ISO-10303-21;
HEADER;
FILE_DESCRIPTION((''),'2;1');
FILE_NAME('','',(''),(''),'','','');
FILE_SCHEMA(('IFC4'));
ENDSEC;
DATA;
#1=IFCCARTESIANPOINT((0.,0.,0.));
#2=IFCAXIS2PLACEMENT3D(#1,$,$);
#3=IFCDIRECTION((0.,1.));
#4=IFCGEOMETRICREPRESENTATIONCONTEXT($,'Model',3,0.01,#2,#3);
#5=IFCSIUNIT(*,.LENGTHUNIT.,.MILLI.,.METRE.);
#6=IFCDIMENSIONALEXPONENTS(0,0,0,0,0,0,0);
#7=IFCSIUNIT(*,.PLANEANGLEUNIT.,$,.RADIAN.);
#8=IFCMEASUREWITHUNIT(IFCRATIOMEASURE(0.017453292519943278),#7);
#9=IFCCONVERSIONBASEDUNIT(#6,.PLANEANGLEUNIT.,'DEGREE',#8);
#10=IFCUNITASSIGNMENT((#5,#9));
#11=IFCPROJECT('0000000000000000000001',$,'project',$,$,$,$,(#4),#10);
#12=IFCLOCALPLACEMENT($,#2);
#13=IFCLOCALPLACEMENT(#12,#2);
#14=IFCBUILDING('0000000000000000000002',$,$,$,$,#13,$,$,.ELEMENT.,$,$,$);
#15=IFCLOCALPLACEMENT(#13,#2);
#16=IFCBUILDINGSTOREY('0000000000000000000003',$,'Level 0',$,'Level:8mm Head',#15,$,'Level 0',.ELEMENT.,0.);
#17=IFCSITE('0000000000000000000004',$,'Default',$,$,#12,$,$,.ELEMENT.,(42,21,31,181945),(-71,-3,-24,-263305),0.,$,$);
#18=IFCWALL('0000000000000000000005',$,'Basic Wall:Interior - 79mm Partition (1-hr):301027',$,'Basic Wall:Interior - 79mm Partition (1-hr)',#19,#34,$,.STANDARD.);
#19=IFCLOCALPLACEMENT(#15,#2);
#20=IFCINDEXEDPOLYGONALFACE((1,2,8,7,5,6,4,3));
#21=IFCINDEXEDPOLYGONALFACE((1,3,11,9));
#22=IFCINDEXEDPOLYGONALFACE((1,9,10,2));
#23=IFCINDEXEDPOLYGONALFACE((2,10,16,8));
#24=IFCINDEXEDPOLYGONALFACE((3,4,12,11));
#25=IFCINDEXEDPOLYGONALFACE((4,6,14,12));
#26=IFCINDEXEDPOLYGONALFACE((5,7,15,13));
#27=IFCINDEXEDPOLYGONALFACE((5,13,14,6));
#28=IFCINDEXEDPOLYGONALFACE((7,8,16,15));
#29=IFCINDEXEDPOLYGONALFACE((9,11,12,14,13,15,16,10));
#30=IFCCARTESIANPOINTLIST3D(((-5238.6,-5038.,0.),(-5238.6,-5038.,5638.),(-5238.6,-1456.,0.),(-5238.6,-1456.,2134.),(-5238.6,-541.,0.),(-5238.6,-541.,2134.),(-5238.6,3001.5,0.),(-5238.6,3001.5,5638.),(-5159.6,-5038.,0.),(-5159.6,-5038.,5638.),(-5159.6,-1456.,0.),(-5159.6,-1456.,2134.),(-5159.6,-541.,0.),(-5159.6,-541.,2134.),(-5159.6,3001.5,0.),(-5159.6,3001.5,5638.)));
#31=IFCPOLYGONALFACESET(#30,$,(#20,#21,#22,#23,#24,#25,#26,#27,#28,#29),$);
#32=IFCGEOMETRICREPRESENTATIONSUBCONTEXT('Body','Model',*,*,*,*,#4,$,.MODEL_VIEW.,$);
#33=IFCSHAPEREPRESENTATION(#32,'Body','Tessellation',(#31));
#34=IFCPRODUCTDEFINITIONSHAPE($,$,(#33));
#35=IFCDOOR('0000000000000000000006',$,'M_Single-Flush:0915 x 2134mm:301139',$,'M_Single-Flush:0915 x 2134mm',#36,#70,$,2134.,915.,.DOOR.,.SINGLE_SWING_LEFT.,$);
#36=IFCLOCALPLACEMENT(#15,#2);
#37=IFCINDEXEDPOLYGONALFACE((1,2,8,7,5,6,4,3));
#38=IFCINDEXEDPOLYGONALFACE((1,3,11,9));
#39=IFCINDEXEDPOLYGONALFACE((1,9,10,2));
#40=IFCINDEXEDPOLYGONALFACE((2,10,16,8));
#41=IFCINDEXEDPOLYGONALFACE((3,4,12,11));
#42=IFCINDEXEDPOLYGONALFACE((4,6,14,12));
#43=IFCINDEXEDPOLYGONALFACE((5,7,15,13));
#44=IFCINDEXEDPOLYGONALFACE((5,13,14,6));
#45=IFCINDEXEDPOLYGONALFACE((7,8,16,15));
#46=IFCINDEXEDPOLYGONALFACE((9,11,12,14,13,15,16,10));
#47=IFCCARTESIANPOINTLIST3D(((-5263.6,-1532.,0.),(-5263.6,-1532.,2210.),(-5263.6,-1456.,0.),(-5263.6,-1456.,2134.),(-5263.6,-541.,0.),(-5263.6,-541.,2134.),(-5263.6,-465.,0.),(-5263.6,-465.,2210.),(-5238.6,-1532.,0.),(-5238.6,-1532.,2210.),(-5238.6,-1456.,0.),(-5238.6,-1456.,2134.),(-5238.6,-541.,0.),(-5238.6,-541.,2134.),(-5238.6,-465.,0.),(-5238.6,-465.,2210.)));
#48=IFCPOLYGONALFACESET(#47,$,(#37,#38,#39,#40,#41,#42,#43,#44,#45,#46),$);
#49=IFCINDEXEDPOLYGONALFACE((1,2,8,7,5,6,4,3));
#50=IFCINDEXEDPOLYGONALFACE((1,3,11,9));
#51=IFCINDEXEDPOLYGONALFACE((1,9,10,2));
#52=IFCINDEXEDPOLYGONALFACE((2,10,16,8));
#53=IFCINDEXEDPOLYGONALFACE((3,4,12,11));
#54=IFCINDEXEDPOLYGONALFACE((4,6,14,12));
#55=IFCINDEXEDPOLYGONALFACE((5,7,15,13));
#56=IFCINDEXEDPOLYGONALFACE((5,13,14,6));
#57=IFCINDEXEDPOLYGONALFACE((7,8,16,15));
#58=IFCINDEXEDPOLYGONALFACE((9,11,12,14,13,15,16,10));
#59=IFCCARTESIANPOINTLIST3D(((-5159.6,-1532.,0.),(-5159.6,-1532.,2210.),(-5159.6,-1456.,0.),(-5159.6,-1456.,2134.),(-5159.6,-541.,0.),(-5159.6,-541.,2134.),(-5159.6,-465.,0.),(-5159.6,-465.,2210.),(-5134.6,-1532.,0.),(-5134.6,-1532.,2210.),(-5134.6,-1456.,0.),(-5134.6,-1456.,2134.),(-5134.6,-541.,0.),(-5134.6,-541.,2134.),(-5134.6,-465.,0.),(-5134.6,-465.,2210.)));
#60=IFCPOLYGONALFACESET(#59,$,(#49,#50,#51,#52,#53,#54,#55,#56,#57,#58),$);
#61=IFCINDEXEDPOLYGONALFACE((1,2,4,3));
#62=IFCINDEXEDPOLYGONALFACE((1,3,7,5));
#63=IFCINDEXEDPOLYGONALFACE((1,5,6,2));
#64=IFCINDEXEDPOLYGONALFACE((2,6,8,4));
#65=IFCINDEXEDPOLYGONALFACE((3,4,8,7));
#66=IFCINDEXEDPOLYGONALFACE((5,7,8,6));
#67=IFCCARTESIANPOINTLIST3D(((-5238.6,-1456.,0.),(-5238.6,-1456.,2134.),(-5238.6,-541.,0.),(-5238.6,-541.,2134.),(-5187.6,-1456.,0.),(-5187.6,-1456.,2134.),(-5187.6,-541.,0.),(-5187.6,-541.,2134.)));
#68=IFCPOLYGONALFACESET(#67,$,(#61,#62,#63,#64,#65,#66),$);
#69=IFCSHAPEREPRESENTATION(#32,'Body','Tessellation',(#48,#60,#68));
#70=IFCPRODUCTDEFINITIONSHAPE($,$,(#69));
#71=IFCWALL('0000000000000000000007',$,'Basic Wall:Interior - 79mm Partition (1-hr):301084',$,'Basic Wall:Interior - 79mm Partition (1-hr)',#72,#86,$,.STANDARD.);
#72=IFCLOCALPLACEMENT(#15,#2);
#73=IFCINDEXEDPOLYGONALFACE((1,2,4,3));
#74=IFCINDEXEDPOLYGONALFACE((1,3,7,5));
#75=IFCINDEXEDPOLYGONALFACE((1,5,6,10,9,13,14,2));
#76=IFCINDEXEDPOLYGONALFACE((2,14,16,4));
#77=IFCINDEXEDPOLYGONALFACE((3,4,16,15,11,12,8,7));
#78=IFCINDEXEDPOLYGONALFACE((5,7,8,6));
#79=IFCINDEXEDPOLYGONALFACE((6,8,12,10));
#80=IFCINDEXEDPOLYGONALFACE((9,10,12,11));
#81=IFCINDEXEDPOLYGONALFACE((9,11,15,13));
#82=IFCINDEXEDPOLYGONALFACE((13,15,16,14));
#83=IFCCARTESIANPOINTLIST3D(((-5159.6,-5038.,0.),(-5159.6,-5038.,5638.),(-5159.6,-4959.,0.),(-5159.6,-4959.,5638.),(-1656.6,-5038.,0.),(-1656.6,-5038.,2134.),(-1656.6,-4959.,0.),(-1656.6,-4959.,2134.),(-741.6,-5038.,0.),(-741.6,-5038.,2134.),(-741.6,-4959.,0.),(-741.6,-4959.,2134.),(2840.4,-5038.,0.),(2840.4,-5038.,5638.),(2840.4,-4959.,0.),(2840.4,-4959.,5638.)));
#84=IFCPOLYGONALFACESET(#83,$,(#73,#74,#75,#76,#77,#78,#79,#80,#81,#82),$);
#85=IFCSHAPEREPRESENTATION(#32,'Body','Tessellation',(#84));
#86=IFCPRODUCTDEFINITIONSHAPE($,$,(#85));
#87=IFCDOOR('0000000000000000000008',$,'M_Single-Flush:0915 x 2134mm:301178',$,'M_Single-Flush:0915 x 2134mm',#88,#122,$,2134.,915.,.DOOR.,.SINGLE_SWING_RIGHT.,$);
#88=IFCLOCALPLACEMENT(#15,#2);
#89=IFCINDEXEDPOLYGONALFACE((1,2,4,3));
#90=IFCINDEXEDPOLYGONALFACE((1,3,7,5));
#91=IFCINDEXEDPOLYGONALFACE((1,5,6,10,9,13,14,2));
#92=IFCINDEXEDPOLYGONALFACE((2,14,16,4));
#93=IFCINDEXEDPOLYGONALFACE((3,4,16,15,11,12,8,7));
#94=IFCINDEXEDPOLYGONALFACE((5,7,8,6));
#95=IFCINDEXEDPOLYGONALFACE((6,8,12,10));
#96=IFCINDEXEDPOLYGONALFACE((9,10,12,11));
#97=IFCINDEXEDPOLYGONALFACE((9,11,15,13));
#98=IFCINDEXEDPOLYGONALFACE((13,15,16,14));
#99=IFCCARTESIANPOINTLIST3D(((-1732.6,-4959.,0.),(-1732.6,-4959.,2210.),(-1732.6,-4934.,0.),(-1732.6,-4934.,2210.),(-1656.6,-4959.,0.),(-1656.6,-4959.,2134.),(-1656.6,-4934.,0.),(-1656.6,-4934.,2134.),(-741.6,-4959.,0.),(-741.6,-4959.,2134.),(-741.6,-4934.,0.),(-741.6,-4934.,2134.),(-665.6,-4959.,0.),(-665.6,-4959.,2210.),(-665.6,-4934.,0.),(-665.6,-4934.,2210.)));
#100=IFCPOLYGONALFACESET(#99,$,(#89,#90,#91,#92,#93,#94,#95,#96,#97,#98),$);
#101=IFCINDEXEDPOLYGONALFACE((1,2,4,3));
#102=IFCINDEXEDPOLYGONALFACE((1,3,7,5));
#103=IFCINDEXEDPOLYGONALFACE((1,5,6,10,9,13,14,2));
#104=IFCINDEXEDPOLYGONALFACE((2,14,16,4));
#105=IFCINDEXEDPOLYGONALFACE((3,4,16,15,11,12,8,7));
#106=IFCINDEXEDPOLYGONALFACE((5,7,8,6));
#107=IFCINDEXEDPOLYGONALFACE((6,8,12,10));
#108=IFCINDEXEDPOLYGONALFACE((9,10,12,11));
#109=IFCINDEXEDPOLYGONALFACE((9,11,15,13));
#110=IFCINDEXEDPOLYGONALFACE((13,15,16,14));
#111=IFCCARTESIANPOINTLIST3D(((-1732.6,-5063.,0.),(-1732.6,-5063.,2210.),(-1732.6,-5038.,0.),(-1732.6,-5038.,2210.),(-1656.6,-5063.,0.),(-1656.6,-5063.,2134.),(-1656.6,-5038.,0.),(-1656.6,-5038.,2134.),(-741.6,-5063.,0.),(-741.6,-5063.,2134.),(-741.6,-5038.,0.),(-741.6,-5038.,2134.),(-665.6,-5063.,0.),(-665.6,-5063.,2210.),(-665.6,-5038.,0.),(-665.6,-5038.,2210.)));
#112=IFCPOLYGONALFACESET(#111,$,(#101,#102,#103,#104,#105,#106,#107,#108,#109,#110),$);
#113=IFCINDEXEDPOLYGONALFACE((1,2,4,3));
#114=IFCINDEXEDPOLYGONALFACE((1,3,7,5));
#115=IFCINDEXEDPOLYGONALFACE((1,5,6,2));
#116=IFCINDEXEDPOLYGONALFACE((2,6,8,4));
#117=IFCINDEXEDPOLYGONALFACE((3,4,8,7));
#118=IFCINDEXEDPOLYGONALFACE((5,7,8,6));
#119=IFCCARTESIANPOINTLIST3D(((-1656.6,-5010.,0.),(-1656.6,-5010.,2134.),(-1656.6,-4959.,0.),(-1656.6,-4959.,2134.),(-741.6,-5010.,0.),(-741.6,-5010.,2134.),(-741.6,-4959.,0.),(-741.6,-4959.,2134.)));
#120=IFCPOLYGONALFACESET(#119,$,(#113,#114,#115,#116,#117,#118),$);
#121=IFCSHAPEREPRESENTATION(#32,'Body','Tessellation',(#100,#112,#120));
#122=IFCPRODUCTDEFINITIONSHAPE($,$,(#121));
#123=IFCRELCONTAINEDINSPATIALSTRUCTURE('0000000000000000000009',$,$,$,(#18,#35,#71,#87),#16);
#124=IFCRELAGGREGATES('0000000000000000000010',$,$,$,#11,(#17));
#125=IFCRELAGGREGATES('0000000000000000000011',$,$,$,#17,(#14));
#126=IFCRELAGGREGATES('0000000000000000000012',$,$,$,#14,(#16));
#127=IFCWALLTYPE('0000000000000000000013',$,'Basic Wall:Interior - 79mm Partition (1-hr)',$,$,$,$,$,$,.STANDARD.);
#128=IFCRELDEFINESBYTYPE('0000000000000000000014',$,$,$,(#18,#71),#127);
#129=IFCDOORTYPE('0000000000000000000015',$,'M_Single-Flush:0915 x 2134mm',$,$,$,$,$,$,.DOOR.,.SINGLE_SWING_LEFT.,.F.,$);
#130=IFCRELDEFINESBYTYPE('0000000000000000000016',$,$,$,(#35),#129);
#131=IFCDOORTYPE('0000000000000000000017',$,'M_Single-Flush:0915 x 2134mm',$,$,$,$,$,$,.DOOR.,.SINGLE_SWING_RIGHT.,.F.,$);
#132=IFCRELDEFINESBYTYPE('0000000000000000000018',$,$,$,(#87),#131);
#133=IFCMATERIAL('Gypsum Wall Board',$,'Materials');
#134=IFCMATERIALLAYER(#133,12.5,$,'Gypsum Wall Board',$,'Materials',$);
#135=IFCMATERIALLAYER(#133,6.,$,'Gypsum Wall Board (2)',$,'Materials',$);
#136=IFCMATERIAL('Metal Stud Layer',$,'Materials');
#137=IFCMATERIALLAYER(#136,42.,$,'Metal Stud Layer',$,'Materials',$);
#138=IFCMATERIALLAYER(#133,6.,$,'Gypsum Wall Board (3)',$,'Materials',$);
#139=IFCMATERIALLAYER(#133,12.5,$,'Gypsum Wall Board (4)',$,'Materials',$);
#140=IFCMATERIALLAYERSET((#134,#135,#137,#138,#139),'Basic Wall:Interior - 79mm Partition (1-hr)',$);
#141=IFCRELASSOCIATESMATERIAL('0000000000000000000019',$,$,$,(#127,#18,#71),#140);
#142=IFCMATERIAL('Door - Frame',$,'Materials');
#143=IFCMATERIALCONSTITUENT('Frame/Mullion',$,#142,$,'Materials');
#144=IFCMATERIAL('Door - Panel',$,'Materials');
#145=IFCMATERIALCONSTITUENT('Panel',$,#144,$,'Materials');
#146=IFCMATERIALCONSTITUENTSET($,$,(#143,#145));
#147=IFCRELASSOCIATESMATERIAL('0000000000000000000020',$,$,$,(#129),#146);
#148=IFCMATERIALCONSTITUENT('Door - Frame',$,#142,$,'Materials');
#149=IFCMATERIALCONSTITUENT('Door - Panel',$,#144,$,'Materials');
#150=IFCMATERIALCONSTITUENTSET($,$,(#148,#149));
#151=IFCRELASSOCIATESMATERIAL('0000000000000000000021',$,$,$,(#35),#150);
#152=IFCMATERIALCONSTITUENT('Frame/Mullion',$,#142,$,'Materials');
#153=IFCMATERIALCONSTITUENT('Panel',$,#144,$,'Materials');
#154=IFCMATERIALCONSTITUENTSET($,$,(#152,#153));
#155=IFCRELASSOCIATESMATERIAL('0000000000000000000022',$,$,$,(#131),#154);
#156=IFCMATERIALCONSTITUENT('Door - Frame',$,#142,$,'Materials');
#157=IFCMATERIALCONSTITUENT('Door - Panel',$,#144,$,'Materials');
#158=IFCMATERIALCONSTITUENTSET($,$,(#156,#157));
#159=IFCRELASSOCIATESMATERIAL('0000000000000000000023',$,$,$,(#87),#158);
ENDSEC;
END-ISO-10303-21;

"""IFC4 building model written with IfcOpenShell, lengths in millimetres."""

from ifc_helpers import new_model, entity, si_unit, converted_unit, direction, frame, frame_2d, origin, origin_2d_with_axis, place, context, subcontext, project, spatial, polyline, rectangle, outline, extrude, clip, bounded_halfspace, source, transform, mapped, material, layer, layer_set, layer_usage, constituent, constituent_set, type_object, type_shapes, element, fill, save


model = new_model("IFC4")

# Units and contexts
model_context = context("Model", 3, precision=0.01, world=origin(), true_north=direction((0.0, 1.0)))
body_context = subcontext(model_context, "Body", "Model", "MODEL_VIEW")
ifc_project = project(units=[si_unit("LENGTHUNIT", "METRE", prefix="MILLI"), converted_unit("PLANEANGLEUNIT", "DEGREE", entity("IfcRatioMeasure", 0.017453292519943278), si_unit("PLANEANGLEUNIT", "RADIAN"), dimensions=[0, 0, 0, 0, 0, 0, 0])], contexts=[model_context])

# Site, building, storey
site_placement = place(None, origin())
site = spatial("IfcSite", under=ifc_project, at=site_placement, Name="Default", CompositionType="ELEMENT", RefLatitude=(42, 21, 31, 181945), RefLongitude=(-71, -3, -24, -263305), RefElevation=0.0)
building_placement = place(site_placement, origin())
building = spatial("IfcBuilding", under=site, at=building_placement, CompositionType="ELEMENT")
storey_placement = place(building_placement, origin())
storey = spatial("IfcBuildingStorey", under=building, at=storey_placement, Name="Level 0", ObjectType="Level:8mm Head", LongName="Level 0", CompositionType="ELEMENT", Elevation=0.0)

# Shared definitions
ifc_material_1 = material(Name="Metal Stud Layer", Category="Materials")
ifc_material_2 = material(Name="Gypsum Wall Board", Category="Materials")
ifc_material_3 = material(Name="Door - Frame", Category="Materials")
ifc_material_4 = material(Name="Door - Panel", Category="Materials")

# Walls, openings, doors
ifc_layer_1 = layer(ifc_material_2, 12.5, Name="Gypsum Wall Board", Category="Materials")
ifc_layer_2 = layer(ifc_material_2, 6.0, Name="Gypsum Wall Board (2)", Category="Materials")
ifc_layer_3 = layer(ifc_material_1, 42.0, Name="Metal Stud Layer", Category="Materials")
ifc_layer_4 = layer(ifc_material_2, 6.0, Name="Gypsum Wall Board (3)", Category="Materials")
ifc_layer_5 = layer(ifc_material_2, 12.5, Name="Gypsum Wall Board (4)", Category="Materials")
ifc_layer_set_1 = layer_set([ifc_layer_1, ifc_layer_2, ifc_layer_3, ifc_layer_4, ifc_layer_5], Name="Basic Wall:Interior - 79mm Partition (1-hr)")
ifc_layer_usage_1 = layer_usage(ifc_layer_set_1, "AXIS2", "NEGATIVE", 39.5)
wall_type_1 = type_object("IfcWallType", Name="Basic Wall:Interior - 79mm Partition (1-hr)", PredefinedType="STANDARD", material=ifc_layer_set_1)
wall_1_placement = place(storey_placement, frame((-5199.1, 3001.5, 0.0), z_axis=(0.0, 0.0, 1.0), x_axis=(0.0, -1.0, 0.0)))
wall_1 = element("IfcWall", 1, at=wall_1_placement, inside=storey, type_object=wall_type_1, material=ifc_layer_usage_1, Name="Basic Wall:Interior - 79mm Partition (1-hr):301027", ObjectType="Basic Wall:Interior - 79mm Partition (1-hr)", PredefinedType="STANDARD", context=body_context, shape_type="Clipping", body=[
    clip(extrude(rectangle(XDim=8039.5, YDim=79.0, at=frame_2d((4019.8, 0.0), x_axis=(1.0, 0.0))), origin(), (0.0, 0.0, 1.0), 5638.0), bounded_halfspace(frame((0.0, -39.5, 5638.0), z_axis=(0.0, 0.0, -1.0), x_axis=(1.0, 0.0, 0.0)), True, frame((0.0, -39.5, 5638.0)), polyline([(0.0, 0.0), (2450439.6, 0.0), (2450439.6, 24079.2), (2426360.4, 24079.2), (0.0, 24079.2), (0.0, 0.0)]))),
])
opening_1_placement = place(wall_1_placement, frame((4457.5, 39.5, 0.0)))
opening_1 = element("IfcOpeningElement", 2, at=opening_1_placement, cuts=wall_1, PredefinedType="OPENING", context=body_context, shape_type="SweptSolid", body=[
    extrude(rectangle(XDim=915.0, YDim=2134.0, at=frame_2d((1067.0, 457.5), x_axis=(0.0, -1.0))), frame((0.0, 0.0, 0.0), z_axis=(0.0, -1.0, 0.0), x_axis=(0.0, 0.0, 1.0)), (0.0, 0.0, 1.0), 79.0),
])
ifc_constituent_1 = constituent(ifc_material_3, Name="Door - Frame", Category="Materials")
ifc_constituent_2 = constituent(ifc_material_4, Name="Door - Panel", Category="Materials")
ifc_constituent_set_1 = constituent_set(constituents=[ifc_constituent_1, ifc_constituent_2])
ifc_constituent_3 = constituent(ifc_material_3, Name="Frame/Mullion", Category="Materials")
ifc_constituent_4 = constituent(ifc_material_4, Name="Panel", Category="Materials")
ifc_constituent_set_2 = constituent_set(constituents=[ifc_constituent_3, ifc_constituent_4])
door_type_1 = type_object("IfcDoorType", Name="M_Single-Flush:0915 x 2134mm", OperationType="SINGLE_SWING_LEFT", ParameterTakesPrecedence=False, PredefinedType="DOOR", material=ifc_constituent_set_2)
shared_shape_1 = source(origin(), body_context, "Body", "SweptSolid", [
    extrude(outline(polyline([(-533.5, -1124.0), (533.5, -1124.0), (533.5, 1086.0), (457.5, 1086.0), (457.5, -1048.0), (-457.5, -1048.0), (-457.5, 1086.0), (-533.5, 1086.0), (-533.5, -1124.0)])), frame((457.5, 104.0, 1086.0), z_axis=(0.0, -1.0, 0.0), x_axis=(-1.0, 0.0, 0.0)), (0.0, 0.0, 1.0), 25.0),
    extrude(outline(polyline([(-1124.0, -533.5), (1086.0, -533.5), (1086.0, -457.5), (-1048.0, -457.5), (-1048.0, 457.5), (1086.0, 457.5), (1086.0, 533.5), (-1124.0, 533.5), (-1124.0, -533.5)])), frame((457.5, 0.0, 1086.0), z_axis=(0.0, -1.0, 0.0), x_axis=(0.0, 0.0, -1.0)), (0.0, 0.0, 1.0), 25.0),
    extrude(rectangle(XDim=915.0, YDim=51.0, at=origin_2d_with_axis()), frame((457.5, 53.5, 0.0)), (0.0, 0.0, 1.0), 2134.0),
])
type_shapes(door_type_1, [shared_shape_1])
door_1_placement = place(opening_1_placement, frame((0.0, 0.0, 0.0), z_axis=(0.0, 0.0, 1.0), x_axis=(-1.0, 0.0, 0.0)))
door_1 = element("IfcDoor", 3, at=door_1_placement, inside=storey, type_object=door_type_1, material=ifc_constituent_set_1, Name="M_Single-Flush:0915 x 2134mm:301139", ObjectType="M_Single-Flush:0915 x 2134mm", OperationType="SINGLE_SWING_LEFT", OverallHeight=2134.0, OverallWidth=915.0, PredefinedType="DOOR", context=body_context, shape_type="MappedRepresentation", body=[
    mapped(shared_shape_1, transform((0.0, 0.0, 0.0), scale=1.0)),
])
fill(opening_1, door_1)
wall_2_placement = place(storey_placement, frame((-5159.6, -4998.5, 0.0)))
wall_2 = element("IfcWall", 4, at=wall_2_placement, inside=storey, type_object=wall_type_1, material=ifc_layer_usage_1, Name="Basic Wall:Interior - 79mm Partition (1-hr):301084", ObjectType="Basic Wall:Interior - 79mm Partition (1-hr)", PredefinedType="STANDARD", context=body_context, shape_type="Clipping", body=[
    clip(extrude(rectangle(XDim=8000.0, YDim=79.0, at=frame_2d((4000.0, 0.0), x_axis=(1.0, 0.0))), origin(), (0.0, 0.0, 1.0), 5638.0), bounded_halfspace(frame((0.0, -39.5, 5638.0), z_axis=(0.0, 0.0, -1.0), x_axis=(0.0, -1.0, 0.0)), True, frame((0.0, -39.5, 5638.0)), polyline([(0.0, 0.0), (2414320.8, 0.0), (2438400.0, 0.0), (2438400.0, 24079.2), (0.0, 24079.2), (0.0, 0.0)]))),
])
opening_2_placement = place(wall_2_placement, frame((3503.0, -39.5, 0.0)))
opening_2 = element("IfcOpeningElement", 5, at=opening_2_placement, cuts=wall_2, PredefinedType="OPENING", context=body_context, shape_type="SweptSolid", body=[
    extrude(rectangle(XDim=915.0, YDim=2134.0, at=frame_2d((1067.0, 457.5), x_axis=(0.0, 1.0))), frame((0.0, 0.0, 0.0), z_axis=(0.0, 1.0, 0.0), x_axis=(0.0, 0.0, 1.0)), (0.0, 0.0, 1.0), 79.0),
])
ifc_constituent_5 = constituent(ifc_material_3, Name="Door - Frame", Category="Materials")
ifc_constituent_6 = constituent(ifc_material_4, Name="Door - Panel", Category="Materials")
ifc_constituent_set_3 = constituent_set(constituents=[ifc_constituent_5, ifc_constituent_6])
ifc_constituent_7 = constituent(ifc_material_3, Name="Frame/Mullion", Category="Materials")
ifc_constituent_8 = constituent(ifc_material_4, Name="Panel", Category="Materials")
ifc_constituent_set_4 = constituent_set(constituents=[ifc_constituent_7, ifc_constituent_8])
door_type_2 = type_object("IfcDoorType", Name="M_Single-Flush:0915 x 2134mm", OperationType="SINGLE_SWING_RIGHT", ParameterTakesPrecedence=False, PredefinedType="DOOR", material=ifc_constituent_set_4)
shared_shape_2 = source(origin(), body_context, "Body", "SweptSolid", [
    extrude(outline(polyline([(-533.5, -1124.0), (533.5, -1124.0), (533.5, 1086.0), (457.5, 1086.0), (457.5, -1048.0), (-457.5, -1048.0), (-457.5, 1086.0), (-533.5, 1086.0), (-533.5, -1124.0)])), frame((457.5, 79.0, 1086.0), z_axis=(0.0, 1.0, 0.0), x_axis=(1.0, 0.0, 0.0)), (0.0, 0.0, 1.0), 25.0),
    extrude(outline(polyline([(-1124.0, -533.5), (1086.0, -533.5), (1086.0, -457.5), (-1048.0, -457.5), (-1048.0, 457.5), (1086.0, 457.5), (1086.0, 533.5), (-1124.0, 533.5), (-1124.0, -533.5)])), frame((457.5, -25.0, 1086.0), z_axis=(0.0, 1.0, 0.0), x_axis=(0.0, 0.0, -1.0)), (0.0, 0.0, 1.0), 25.0),
    extrude(rectangle(XDim=51.0, YDim=915.0, at=origin_2d_with_axis()), frame((457.5, 53.5, 0.0), z_axis=(0.0, 0.0, 1.0), x_axis=(0.0, 1.0, 0.0)), (0.0, 0.0, 1.0), 2134.0),
])
type_shapes(door_type_2, [shared_shape_2])
door_2_placement = place(opening_2_placement, origin())
door_2 = element("IfcDoor", 6, at=door_2_placement, inside=storey, type_object=door_type_2, material=ifc_constituent_set_3, Name="M_Single-Flush:0915 x 2134mm:301178", ObjectType="M_Single-Flush:0915 x 2134mm", OperationType="SINGLE_SWING_RIGHT", OverallHeight=2134.0, OverallWidth=915.0, PredefinedType="DOOR", context=body_context, shape_type="MappedRepresentation", body=[
    mapped(shared_shape_2, transform((0.0, 0.0, 0.0), scale=1.0)),
])
fill(opening_2, door_2)

save(model, "model.ifc")
